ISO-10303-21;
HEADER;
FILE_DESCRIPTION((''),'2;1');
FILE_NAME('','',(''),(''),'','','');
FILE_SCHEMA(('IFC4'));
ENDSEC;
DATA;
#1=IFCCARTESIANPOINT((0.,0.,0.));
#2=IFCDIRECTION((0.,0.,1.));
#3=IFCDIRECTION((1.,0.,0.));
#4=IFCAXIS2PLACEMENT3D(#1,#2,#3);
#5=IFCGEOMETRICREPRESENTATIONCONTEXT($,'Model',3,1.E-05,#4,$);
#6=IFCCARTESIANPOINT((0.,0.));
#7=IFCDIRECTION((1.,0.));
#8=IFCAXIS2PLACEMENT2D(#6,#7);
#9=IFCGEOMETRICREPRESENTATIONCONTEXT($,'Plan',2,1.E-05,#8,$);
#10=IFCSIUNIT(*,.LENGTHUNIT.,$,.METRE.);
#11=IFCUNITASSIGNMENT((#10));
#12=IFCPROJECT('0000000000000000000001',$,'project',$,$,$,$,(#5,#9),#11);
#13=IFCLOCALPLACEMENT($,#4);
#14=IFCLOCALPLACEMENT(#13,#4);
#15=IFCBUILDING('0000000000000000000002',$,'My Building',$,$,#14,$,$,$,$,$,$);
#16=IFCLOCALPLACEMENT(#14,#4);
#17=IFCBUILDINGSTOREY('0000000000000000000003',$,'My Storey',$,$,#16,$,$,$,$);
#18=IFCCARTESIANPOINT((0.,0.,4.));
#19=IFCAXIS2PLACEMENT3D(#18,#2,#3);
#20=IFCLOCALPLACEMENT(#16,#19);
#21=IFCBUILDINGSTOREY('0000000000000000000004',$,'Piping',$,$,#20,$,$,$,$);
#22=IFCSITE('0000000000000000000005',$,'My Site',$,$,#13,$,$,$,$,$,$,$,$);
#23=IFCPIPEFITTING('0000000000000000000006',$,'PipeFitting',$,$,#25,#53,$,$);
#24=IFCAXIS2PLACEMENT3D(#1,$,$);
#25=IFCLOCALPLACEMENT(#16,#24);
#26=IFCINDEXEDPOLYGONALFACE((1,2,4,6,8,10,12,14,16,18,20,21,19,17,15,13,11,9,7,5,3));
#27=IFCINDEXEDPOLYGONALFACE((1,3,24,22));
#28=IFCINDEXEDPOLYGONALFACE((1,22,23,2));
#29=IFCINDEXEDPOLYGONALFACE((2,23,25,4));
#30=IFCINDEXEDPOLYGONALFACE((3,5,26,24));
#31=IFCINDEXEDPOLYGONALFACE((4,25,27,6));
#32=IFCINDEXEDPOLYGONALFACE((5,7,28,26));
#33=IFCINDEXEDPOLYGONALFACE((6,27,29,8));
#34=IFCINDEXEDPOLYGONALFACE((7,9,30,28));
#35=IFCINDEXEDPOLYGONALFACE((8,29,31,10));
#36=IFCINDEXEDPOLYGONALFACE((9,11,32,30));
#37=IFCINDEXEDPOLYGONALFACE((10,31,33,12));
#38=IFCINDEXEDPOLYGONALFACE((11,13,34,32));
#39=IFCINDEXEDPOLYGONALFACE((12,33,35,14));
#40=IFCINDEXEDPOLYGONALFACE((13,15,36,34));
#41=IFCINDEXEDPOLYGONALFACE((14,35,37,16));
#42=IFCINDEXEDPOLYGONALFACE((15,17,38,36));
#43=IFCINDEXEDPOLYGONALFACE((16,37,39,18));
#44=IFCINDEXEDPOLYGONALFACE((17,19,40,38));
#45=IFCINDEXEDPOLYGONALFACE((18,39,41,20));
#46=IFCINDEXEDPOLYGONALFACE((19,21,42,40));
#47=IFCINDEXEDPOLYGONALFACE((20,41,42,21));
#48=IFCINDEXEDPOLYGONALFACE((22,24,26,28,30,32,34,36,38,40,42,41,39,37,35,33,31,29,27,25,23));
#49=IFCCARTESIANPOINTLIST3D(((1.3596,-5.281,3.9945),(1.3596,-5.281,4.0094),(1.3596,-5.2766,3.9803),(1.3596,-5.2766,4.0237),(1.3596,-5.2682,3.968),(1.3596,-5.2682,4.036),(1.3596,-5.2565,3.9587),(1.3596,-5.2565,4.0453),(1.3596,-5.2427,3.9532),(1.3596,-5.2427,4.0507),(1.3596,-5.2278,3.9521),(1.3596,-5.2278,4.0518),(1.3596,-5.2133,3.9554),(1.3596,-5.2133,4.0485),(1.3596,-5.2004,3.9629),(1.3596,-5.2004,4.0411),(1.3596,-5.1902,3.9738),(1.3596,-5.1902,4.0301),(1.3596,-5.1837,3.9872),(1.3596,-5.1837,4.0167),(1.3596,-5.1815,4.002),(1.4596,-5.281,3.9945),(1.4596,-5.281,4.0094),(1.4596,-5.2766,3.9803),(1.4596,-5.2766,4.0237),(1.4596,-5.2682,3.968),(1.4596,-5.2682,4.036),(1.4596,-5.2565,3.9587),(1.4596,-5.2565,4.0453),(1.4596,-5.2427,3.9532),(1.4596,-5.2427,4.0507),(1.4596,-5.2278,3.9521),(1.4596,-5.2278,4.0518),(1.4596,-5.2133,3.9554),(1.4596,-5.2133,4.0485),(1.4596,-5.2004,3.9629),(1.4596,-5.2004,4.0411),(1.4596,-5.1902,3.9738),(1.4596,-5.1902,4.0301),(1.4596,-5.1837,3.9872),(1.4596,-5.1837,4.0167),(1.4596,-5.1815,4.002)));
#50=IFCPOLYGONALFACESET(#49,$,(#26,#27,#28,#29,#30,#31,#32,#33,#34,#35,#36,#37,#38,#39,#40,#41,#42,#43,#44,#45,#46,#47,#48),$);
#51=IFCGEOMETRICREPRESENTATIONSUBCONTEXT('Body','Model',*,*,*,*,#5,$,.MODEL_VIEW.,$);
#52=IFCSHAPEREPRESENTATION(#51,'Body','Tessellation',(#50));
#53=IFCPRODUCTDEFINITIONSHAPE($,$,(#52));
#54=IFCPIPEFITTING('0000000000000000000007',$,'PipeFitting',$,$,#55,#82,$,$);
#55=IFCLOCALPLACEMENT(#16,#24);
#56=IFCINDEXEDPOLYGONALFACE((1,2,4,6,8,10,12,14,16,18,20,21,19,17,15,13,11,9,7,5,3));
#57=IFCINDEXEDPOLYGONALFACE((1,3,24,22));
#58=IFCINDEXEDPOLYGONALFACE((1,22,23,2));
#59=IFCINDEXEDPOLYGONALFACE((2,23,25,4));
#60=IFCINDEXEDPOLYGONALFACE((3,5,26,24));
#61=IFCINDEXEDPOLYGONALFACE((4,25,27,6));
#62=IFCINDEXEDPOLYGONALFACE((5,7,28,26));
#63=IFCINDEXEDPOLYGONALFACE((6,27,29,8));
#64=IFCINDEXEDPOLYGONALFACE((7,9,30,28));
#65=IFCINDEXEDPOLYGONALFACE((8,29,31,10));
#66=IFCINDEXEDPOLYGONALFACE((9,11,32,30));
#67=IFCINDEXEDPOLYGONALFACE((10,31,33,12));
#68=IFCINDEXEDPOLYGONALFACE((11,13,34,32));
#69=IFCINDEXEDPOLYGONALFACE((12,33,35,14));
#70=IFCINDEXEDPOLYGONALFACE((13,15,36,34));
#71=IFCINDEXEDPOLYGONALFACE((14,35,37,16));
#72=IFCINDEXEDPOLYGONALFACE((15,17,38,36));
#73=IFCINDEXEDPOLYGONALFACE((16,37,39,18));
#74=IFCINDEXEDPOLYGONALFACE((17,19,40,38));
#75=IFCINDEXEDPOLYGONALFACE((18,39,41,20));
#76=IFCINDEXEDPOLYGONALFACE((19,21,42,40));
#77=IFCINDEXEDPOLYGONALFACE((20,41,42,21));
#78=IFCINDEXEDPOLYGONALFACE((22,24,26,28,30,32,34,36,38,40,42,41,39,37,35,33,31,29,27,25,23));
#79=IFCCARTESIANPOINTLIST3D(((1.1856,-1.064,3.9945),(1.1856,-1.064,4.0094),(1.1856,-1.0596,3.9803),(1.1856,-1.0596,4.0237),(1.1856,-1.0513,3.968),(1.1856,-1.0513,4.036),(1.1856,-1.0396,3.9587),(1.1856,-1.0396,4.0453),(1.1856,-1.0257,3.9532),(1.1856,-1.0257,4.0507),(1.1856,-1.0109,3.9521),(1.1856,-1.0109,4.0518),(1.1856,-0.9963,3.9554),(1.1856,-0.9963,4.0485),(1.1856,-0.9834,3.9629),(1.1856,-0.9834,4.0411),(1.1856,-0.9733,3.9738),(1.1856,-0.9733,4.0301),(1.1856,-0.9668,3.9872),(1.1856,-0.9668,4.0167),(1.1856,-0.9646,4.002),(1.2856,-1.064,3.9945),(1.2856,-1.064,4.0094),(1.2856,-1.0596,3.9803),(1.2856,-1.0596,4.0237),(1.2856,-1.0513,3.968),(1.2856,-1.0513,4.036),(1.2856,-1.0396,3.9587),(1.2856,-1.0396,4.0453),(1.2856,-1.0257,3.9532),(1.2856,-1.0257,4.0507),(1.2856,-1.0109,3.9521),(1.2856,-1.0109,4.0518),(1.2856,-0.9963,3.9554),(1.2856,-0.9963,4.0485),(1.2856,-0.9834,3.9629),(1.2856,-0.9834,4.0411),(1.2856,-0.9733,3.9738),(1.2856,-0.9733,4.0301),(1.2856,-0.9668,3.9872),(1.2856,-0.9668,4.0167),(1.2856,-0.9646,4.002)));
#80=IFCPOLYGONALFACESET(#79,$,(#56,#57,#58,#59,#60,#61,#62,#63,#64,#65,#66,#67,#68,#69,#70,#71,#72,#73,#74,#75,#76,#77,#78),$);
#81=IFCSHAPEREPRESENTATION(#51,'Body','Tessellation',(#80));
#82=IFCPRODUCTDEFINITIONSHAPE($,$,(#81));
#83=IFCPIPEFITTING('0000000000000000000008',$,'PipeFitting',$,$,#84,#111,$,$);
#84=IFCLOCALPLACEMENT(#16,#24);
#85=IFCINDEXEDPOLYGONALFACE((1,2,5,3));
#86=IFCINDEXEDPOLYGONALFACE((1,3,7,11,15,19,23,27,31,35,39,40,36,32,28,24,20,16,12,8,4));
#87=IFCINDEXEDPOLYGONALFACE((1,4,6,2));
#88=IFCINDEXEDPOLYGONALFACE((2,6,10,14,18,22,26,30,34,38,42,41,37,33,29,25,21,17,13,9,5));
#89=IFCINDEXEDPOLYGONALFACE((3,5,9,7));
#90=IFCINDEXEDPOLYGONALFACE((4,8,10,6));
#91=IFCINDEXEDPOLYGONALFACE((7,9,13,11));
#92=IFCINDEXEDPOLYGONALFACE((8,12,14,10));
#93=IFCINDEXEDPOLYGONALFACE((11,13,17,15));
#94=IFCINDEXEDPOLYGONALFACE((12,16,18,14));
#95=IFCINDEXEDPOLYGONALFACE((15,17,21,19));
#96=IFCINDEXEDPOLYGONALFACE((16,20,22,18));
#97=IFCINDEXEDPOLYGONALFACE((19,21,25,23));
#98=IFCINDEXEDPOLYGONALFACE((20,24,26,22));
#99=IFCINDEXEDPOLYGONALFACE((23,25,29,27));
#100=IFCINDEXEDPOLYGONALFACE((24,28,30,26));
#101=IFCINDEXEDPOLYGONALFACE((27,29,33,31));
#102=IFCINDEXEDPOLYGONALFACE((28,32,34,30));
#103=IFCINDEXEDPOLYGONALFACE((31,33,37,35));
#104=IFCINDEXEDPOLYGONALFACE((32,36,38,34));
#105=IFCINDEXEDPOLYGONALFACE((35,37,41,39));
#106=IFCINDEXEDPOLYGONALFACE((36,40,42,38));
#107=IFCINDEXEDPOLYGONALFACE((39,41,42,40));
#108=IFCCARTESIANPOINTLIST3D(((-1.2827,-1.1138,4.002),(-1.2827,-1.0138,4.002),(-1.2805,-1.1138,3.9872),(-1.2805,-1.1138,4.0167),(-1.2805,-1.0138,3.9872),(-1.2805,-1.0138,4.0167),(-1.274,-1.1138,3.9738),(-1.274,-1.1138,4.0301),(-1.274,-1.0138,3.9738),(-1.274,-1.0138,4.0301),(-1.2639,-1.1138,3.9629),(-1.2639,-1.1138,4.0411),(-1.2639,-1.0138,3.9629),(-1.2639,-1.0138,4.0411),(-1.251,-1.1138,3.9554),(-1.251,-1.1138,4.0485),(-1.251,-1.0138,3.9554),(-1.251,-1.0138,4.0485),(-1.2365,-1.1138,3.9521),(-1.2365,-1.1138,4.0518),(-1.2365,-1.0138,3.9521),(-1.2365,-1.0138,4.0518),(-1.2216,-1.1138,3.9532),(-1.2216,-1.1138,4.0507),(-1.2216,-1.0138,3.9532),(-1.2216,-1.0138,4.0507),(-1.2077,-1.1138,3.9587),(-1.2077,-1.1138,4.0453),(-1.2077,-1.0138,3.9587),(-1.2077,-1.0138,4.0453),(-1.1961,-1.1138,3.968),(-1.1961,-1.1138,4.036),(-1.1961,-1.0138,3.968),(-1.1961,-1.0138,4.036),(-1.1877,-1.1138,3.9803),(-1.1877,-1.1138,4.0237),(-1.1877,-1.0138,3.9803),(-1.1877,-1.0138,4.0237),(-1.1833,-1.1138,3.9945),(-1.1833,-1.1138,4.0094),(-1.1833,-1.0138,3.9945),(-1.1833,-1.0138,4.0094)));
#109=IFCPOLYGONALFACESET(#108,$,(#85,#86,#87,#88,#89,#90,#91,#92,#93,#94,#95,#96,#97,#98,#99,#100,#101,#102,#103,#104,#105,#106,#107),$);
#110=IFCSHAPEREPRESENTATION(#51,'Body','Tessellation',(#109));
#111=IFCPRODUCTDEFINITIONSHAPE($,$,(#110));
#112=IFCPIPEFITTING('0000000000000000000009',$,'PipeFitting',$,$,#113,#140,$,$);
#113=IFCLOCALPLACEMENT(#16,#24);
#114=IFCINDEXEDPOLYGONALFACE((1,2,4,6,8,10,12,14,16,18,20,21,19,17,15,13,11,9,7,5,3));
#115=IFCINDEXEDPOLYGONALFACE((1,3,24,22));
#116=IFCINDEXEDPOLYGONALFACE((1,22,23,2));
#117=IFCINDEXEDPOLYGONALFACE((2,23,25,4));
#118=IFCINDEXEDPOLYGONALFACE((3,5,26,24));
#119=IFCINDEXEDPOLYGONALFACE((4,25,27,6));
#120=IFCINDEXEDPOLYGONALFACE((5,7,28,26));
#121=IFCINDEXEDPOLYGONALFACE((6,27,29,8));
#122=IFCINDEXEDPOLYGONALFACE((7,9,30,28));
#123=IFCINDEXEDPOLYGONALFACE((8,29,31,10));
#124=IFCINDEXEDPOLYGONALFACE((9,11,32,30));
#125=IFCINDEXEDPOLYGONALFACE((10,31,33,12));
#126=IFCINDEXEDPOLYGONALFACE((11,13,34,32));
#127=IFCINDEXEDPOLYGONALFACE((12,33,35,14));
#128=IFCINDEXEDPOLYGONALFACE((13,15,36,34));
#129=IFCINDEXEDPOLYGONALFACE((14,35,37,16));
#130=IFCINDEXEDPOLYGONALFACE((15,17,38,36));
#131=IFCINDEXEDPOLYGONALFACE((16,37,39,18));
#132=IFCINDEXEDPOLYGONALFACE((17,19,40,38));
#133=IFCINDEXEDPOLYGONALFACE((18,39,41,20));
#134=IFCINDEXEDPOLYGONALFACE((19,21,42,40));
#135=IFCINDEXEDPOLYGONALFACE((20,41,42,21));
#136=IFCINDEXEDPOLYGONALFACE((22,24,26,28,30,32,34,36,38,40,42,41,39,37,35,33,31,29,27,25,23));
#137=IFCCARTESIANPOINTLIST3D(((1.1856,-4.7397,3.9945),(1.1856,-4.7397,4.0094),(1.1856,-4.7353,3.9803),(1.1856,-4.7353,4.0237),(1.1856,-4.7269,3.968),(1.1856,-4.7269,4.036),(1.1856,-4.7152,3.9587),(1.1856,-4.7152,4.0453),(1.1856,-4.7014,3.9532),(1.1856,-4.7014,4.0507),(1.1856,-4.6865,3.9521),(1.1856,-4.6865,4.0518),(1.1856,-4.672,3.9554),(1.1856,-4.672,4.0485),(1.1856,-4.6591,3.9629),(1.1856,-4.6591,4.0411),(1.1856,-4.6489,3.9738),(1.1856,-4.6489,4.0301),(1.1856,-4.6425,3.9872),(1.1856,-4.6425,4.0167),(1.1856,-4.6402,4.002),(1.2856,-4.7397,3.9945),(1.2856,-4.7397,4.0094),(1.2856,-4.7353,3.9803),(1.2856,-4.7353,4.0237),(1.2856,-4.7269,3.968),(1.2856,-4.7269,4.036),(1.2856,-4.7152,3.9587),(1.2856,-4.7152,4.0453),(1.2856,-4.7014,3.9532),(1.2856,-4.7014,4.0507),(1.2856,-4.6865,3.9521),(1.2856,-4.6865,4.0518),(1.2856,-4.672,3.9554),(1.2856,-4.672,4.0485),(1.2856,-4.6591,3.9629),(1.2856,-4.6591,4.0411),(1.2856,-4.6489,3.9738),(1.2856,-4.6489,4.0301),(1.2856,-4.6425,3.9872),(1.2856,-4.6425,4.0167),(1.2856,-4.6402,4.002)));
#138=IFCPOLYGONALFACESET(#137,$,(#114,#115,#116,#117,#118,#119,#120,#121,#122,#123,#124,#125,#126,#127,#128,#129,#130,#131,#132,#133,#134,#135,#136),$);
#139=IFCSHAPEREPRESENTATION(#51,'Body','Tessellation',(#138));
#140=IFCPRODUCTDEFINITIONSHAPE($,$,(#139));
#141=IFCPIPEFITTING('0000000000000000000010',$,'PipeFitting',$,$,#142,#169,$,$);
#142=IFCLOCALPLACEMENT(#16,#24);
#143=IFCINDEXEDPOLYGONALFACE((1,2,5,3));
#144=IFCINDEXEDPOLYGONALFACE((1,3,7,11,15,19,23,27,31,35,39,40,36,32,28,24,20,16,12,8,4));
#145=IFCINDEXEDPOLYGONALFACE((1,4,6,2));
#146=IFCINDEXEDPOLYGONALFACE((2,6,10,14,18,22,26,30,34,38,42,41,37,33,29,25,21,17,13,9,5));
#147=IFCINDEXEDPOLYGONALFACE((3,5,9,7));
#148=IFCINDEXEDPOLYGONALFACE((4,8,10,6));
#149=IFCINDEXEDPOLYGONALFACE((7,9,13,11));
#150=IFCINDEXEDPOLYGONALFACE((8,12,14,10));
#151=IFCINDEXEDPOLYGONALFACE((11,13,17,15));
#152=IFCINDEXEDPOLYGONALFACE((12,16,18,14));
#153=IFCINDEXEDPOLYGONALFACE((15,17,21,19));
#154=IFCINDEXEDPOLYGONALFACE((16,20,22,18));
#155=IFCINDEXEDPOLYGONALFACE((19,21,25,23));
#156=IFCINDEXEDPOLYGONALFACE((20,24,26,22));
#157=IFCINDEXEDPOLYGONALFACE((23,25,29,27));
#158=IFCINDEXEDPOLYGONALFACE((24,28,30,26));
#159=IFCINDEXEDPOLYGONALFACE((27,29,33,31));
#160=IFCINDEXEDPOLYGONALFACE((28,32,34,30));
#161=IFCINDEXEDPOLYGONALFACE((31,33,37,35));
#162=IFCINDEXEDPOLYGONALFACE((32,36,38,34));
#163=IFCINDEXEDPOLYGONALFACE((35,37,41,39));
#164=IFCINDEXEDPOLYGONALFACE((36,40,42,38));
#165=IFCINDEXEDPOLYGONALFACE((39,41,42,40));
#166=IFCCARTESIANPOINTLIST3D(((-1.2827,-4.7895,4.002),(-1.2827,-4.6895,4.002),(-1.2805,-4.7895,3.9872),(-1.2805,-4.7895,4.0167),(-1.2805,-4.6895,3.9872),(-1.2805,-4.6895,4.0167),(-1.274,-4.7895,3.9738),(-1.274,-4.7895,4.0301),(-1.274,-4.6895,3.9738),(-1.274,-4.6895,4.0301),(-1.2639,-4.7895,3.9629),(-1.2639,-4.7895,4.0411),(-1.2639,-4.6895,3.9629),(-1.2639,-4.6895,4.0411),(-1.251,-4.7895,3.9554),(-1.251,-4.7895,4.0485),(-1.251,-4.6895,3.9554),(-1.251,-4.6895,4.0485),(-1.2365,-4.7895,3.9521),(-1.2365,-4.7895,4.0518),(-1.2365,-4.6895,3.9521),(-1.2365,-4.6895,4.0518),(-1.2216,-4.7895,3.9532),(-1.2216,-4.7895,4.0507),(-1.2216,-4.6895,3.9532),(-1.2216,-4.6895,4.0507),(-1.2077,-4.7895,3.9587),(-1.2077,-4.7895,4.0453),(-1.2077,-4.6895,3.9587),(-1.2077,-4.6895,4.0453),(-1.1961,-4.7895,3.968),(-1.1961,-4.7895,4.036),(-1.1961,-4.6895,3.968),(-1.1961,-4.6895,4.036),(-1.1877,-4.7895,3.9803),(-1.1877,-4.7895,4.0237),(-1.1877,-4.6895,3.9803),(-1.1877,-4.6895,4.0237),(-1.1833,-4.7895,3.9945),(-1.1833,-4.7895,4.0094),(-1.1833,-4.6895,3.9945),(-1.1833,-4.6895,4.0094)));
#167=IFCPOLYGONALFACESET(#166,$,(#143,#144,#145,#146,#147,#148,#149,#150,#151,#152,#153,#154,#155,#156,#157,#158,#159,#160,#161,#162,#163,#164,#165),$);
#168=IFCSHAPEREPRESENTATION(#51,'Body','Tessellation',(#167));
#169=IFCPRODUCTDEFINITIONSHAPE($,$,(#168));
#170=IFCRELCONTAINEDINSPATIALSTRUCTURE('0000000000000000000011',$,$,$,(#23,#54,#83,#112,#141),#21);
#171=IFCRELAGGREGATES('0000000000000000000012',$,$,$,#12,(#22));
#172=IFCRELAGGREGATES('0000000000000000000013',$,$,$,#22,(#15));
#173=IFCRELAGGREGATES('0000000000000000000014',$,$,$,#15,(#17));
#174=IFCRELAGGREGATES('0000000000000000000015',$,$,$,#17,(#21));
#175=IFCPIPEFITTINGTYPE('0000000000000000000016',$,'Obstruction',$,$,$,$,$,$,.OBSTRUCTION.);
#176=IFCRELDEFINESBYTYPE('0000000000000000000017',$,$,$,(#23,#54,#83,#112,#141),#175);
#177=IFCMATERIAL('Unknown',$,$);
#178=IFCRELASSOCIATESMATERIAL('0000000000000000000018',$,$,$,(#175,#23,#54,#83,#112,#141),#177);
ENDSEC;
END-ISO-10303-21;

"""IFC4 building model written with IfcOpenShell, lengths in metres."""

from ifc_helpers import new_model, si_unit, frame, origin_with_axes, origin_2d_with_axis, place, context, subcontext, project, spatial, circle, extrude, material, material_profile, profile_set, profile_usage, type_object, element, save


model = new_model("IFC4")

# Units and contexts
model_context = context("Model", 3, precision=1e-05, world=origin_with_axes())
plan_context = context("Plan", 2, precision=1e-05, world=origin_2d_with_axis())
body_context = subcontext(model_context, "Body", "Model", "MODEL_VIEW")
ifc_project = project(units=[si_unit("LENGTHUNIT", "METRE")], contexts=[model_context, plan_context])

# Site, building, storeys
site_placement = place(None, origin_with_axes())
site = spatial("IfcSite", under=ifc_project, at=site_placement, Name="My Site")
building_placement = place(site_placement, origin_with_axes())
building = spatial("IfcBuilding", under=site, at=building_placement, Name="My Building")
storey_1_placement = place(building_placement, origin_with_axes())
storey_1 = spatial("IfcBuildingStorey", under=building, at=storey_1_placement, Name="My Storey")
storey_2_placement = place(storey_1_placement, frame((0.0, 0.0, 4.0), z_axis=(0.0, 0.0, 1.0), x_axis=(1.0, 0.0, 0.0)))
storey_2 = spatial("IfcBuildingStorey", under=storey_1, at=storey_2_placement, Name="Piping")

# Shared definitions
ifc_material = material(Name="Unknown")

# Pipe fittings
ifc_material_profile_1 = material_profile(ifc_material, circle(Radius=0.05))
ifc_profile_set_1 = profile_set([ifc_material_profile_1])
pipe_fitting_type_1 = type_object("IfcPipeFittingType", Name="Obstruction", PredefinedType="OBSTRUCTION", material=ifc_profile_set_1)
ifc_profile_usage_1 = profile_usage(ifc_profile_set_1, cardinal=5)
pipe_fitting_1_placement = place(storey_2_placement, frame((1.3596, -5.2315, 0.002), z_axis=(1.0, 0.0, 0.0), x_axis=(0.0, 1.0, 0.0)))
element("IfcPipeFitting", 1, at=pipe_fitting_1_placement, inside=storey_2, type_object=pipe_fitting_type_1, material=ifc_profile_usage_1, Name="PipeFitting", context=body_context, shape_type="SweptSolid", body=[
    extrude(circle(Radius=0.05), origin_with_axes(), (0.0, 0.0, 1.0), 0.1),
])
ifc_profile_usage_2 = profile_usage(ifc_profile_set_1, cardinal=5)
pipe_fitting_2_placement = place(storey_2_placement, frame((1.1856, -1.0146, 0.002), z_axis=(1.0, 0.0, 0.0), x_axis=(0.0, 1.0, 0.0)))
element("IfcPipeFitting", 2, at=pipe_fitting_2_placement, inside=storey_2, type_object=pipe_fitting_type_1, material=ifc_profile_usage_2, Name="PipeFitting", context=body_context, shape_type="SweptSolid", body=[
    extrude(circle(Radius=0.05), origin_with_axes(), (0.0, 0.0, 1.0), 0.1),
])
ifc_profile_usage_3 = profile_usage(ifc_profile_set_1, cardinal=5)
pipe_fitting_3_placement = place(storey_2_placement, frame((-1.2327, -1.1138, 0.002), z_axis=(0.0, 1.0, 0.000001), x_axis=(-1.0, 0.0, 0.0)))
element("IfcPipeFitting", 3, at=pipe_fitting_3_placement, inside=storey_2, type_object=pipe_fitting_type_1, material=ifc_profile_usage_3, Name="PipeFitting", context=body_context, shape_type="SweptSolid", body=[
    extrude(circle(Radius=0.05), origin_with_axes(), (0.0, 0.0, 1.0), 0.1),
])
ifc_profile_usage_4 = profile_usage(ifc_profile_set_1, cardinal=5)
pipe_fitting_4_placement = place(storey_2_placement, frame((1.1856, -4.6902, 0.002), z_axis=(1.0, 0.0, 0.0), x_axis=(0.0, 1.0, 0.0)))
element("IfcPipeFitting", 4, at=pipe_fitting_4_placement, inside=storey_2, type_object=pipe_fitting_type_1, material=ifc_profile_usage_4, Name="PipeFitting", context=body_context, shape_type="SweptSolid", body=[
    extrude(circle(Radius=0.05), origin_with_axes(), (0.0, 0.0, 1.0), 0.1),
])
ifc_profile_usage_5 = profile_usage(ifc_profile_set_1, cardinal=5)
pipe_fitting_5_placement = place(storey_2_placement, frame((-1.2327, -4.7895, 0.002), z_axis=(0.0, 1.0, 0.000001), x_axis=(-1.0, 0.0, 0.0)))
element("IfcPipeFitting", 5, at=pipe_fitting_5_placement, inside=storey_2, type_object=pipe_fitting_type_1, material=ifc_profile_usage_5, Name="PipeFitting", context=body_context, shape_type="SweptSolid", body=[
    extrude(circle(Radius=0.05), origin_with_axes(), (0.0, 0.0, 1.0), 0.1),
])

save(model, "model.ifc")
